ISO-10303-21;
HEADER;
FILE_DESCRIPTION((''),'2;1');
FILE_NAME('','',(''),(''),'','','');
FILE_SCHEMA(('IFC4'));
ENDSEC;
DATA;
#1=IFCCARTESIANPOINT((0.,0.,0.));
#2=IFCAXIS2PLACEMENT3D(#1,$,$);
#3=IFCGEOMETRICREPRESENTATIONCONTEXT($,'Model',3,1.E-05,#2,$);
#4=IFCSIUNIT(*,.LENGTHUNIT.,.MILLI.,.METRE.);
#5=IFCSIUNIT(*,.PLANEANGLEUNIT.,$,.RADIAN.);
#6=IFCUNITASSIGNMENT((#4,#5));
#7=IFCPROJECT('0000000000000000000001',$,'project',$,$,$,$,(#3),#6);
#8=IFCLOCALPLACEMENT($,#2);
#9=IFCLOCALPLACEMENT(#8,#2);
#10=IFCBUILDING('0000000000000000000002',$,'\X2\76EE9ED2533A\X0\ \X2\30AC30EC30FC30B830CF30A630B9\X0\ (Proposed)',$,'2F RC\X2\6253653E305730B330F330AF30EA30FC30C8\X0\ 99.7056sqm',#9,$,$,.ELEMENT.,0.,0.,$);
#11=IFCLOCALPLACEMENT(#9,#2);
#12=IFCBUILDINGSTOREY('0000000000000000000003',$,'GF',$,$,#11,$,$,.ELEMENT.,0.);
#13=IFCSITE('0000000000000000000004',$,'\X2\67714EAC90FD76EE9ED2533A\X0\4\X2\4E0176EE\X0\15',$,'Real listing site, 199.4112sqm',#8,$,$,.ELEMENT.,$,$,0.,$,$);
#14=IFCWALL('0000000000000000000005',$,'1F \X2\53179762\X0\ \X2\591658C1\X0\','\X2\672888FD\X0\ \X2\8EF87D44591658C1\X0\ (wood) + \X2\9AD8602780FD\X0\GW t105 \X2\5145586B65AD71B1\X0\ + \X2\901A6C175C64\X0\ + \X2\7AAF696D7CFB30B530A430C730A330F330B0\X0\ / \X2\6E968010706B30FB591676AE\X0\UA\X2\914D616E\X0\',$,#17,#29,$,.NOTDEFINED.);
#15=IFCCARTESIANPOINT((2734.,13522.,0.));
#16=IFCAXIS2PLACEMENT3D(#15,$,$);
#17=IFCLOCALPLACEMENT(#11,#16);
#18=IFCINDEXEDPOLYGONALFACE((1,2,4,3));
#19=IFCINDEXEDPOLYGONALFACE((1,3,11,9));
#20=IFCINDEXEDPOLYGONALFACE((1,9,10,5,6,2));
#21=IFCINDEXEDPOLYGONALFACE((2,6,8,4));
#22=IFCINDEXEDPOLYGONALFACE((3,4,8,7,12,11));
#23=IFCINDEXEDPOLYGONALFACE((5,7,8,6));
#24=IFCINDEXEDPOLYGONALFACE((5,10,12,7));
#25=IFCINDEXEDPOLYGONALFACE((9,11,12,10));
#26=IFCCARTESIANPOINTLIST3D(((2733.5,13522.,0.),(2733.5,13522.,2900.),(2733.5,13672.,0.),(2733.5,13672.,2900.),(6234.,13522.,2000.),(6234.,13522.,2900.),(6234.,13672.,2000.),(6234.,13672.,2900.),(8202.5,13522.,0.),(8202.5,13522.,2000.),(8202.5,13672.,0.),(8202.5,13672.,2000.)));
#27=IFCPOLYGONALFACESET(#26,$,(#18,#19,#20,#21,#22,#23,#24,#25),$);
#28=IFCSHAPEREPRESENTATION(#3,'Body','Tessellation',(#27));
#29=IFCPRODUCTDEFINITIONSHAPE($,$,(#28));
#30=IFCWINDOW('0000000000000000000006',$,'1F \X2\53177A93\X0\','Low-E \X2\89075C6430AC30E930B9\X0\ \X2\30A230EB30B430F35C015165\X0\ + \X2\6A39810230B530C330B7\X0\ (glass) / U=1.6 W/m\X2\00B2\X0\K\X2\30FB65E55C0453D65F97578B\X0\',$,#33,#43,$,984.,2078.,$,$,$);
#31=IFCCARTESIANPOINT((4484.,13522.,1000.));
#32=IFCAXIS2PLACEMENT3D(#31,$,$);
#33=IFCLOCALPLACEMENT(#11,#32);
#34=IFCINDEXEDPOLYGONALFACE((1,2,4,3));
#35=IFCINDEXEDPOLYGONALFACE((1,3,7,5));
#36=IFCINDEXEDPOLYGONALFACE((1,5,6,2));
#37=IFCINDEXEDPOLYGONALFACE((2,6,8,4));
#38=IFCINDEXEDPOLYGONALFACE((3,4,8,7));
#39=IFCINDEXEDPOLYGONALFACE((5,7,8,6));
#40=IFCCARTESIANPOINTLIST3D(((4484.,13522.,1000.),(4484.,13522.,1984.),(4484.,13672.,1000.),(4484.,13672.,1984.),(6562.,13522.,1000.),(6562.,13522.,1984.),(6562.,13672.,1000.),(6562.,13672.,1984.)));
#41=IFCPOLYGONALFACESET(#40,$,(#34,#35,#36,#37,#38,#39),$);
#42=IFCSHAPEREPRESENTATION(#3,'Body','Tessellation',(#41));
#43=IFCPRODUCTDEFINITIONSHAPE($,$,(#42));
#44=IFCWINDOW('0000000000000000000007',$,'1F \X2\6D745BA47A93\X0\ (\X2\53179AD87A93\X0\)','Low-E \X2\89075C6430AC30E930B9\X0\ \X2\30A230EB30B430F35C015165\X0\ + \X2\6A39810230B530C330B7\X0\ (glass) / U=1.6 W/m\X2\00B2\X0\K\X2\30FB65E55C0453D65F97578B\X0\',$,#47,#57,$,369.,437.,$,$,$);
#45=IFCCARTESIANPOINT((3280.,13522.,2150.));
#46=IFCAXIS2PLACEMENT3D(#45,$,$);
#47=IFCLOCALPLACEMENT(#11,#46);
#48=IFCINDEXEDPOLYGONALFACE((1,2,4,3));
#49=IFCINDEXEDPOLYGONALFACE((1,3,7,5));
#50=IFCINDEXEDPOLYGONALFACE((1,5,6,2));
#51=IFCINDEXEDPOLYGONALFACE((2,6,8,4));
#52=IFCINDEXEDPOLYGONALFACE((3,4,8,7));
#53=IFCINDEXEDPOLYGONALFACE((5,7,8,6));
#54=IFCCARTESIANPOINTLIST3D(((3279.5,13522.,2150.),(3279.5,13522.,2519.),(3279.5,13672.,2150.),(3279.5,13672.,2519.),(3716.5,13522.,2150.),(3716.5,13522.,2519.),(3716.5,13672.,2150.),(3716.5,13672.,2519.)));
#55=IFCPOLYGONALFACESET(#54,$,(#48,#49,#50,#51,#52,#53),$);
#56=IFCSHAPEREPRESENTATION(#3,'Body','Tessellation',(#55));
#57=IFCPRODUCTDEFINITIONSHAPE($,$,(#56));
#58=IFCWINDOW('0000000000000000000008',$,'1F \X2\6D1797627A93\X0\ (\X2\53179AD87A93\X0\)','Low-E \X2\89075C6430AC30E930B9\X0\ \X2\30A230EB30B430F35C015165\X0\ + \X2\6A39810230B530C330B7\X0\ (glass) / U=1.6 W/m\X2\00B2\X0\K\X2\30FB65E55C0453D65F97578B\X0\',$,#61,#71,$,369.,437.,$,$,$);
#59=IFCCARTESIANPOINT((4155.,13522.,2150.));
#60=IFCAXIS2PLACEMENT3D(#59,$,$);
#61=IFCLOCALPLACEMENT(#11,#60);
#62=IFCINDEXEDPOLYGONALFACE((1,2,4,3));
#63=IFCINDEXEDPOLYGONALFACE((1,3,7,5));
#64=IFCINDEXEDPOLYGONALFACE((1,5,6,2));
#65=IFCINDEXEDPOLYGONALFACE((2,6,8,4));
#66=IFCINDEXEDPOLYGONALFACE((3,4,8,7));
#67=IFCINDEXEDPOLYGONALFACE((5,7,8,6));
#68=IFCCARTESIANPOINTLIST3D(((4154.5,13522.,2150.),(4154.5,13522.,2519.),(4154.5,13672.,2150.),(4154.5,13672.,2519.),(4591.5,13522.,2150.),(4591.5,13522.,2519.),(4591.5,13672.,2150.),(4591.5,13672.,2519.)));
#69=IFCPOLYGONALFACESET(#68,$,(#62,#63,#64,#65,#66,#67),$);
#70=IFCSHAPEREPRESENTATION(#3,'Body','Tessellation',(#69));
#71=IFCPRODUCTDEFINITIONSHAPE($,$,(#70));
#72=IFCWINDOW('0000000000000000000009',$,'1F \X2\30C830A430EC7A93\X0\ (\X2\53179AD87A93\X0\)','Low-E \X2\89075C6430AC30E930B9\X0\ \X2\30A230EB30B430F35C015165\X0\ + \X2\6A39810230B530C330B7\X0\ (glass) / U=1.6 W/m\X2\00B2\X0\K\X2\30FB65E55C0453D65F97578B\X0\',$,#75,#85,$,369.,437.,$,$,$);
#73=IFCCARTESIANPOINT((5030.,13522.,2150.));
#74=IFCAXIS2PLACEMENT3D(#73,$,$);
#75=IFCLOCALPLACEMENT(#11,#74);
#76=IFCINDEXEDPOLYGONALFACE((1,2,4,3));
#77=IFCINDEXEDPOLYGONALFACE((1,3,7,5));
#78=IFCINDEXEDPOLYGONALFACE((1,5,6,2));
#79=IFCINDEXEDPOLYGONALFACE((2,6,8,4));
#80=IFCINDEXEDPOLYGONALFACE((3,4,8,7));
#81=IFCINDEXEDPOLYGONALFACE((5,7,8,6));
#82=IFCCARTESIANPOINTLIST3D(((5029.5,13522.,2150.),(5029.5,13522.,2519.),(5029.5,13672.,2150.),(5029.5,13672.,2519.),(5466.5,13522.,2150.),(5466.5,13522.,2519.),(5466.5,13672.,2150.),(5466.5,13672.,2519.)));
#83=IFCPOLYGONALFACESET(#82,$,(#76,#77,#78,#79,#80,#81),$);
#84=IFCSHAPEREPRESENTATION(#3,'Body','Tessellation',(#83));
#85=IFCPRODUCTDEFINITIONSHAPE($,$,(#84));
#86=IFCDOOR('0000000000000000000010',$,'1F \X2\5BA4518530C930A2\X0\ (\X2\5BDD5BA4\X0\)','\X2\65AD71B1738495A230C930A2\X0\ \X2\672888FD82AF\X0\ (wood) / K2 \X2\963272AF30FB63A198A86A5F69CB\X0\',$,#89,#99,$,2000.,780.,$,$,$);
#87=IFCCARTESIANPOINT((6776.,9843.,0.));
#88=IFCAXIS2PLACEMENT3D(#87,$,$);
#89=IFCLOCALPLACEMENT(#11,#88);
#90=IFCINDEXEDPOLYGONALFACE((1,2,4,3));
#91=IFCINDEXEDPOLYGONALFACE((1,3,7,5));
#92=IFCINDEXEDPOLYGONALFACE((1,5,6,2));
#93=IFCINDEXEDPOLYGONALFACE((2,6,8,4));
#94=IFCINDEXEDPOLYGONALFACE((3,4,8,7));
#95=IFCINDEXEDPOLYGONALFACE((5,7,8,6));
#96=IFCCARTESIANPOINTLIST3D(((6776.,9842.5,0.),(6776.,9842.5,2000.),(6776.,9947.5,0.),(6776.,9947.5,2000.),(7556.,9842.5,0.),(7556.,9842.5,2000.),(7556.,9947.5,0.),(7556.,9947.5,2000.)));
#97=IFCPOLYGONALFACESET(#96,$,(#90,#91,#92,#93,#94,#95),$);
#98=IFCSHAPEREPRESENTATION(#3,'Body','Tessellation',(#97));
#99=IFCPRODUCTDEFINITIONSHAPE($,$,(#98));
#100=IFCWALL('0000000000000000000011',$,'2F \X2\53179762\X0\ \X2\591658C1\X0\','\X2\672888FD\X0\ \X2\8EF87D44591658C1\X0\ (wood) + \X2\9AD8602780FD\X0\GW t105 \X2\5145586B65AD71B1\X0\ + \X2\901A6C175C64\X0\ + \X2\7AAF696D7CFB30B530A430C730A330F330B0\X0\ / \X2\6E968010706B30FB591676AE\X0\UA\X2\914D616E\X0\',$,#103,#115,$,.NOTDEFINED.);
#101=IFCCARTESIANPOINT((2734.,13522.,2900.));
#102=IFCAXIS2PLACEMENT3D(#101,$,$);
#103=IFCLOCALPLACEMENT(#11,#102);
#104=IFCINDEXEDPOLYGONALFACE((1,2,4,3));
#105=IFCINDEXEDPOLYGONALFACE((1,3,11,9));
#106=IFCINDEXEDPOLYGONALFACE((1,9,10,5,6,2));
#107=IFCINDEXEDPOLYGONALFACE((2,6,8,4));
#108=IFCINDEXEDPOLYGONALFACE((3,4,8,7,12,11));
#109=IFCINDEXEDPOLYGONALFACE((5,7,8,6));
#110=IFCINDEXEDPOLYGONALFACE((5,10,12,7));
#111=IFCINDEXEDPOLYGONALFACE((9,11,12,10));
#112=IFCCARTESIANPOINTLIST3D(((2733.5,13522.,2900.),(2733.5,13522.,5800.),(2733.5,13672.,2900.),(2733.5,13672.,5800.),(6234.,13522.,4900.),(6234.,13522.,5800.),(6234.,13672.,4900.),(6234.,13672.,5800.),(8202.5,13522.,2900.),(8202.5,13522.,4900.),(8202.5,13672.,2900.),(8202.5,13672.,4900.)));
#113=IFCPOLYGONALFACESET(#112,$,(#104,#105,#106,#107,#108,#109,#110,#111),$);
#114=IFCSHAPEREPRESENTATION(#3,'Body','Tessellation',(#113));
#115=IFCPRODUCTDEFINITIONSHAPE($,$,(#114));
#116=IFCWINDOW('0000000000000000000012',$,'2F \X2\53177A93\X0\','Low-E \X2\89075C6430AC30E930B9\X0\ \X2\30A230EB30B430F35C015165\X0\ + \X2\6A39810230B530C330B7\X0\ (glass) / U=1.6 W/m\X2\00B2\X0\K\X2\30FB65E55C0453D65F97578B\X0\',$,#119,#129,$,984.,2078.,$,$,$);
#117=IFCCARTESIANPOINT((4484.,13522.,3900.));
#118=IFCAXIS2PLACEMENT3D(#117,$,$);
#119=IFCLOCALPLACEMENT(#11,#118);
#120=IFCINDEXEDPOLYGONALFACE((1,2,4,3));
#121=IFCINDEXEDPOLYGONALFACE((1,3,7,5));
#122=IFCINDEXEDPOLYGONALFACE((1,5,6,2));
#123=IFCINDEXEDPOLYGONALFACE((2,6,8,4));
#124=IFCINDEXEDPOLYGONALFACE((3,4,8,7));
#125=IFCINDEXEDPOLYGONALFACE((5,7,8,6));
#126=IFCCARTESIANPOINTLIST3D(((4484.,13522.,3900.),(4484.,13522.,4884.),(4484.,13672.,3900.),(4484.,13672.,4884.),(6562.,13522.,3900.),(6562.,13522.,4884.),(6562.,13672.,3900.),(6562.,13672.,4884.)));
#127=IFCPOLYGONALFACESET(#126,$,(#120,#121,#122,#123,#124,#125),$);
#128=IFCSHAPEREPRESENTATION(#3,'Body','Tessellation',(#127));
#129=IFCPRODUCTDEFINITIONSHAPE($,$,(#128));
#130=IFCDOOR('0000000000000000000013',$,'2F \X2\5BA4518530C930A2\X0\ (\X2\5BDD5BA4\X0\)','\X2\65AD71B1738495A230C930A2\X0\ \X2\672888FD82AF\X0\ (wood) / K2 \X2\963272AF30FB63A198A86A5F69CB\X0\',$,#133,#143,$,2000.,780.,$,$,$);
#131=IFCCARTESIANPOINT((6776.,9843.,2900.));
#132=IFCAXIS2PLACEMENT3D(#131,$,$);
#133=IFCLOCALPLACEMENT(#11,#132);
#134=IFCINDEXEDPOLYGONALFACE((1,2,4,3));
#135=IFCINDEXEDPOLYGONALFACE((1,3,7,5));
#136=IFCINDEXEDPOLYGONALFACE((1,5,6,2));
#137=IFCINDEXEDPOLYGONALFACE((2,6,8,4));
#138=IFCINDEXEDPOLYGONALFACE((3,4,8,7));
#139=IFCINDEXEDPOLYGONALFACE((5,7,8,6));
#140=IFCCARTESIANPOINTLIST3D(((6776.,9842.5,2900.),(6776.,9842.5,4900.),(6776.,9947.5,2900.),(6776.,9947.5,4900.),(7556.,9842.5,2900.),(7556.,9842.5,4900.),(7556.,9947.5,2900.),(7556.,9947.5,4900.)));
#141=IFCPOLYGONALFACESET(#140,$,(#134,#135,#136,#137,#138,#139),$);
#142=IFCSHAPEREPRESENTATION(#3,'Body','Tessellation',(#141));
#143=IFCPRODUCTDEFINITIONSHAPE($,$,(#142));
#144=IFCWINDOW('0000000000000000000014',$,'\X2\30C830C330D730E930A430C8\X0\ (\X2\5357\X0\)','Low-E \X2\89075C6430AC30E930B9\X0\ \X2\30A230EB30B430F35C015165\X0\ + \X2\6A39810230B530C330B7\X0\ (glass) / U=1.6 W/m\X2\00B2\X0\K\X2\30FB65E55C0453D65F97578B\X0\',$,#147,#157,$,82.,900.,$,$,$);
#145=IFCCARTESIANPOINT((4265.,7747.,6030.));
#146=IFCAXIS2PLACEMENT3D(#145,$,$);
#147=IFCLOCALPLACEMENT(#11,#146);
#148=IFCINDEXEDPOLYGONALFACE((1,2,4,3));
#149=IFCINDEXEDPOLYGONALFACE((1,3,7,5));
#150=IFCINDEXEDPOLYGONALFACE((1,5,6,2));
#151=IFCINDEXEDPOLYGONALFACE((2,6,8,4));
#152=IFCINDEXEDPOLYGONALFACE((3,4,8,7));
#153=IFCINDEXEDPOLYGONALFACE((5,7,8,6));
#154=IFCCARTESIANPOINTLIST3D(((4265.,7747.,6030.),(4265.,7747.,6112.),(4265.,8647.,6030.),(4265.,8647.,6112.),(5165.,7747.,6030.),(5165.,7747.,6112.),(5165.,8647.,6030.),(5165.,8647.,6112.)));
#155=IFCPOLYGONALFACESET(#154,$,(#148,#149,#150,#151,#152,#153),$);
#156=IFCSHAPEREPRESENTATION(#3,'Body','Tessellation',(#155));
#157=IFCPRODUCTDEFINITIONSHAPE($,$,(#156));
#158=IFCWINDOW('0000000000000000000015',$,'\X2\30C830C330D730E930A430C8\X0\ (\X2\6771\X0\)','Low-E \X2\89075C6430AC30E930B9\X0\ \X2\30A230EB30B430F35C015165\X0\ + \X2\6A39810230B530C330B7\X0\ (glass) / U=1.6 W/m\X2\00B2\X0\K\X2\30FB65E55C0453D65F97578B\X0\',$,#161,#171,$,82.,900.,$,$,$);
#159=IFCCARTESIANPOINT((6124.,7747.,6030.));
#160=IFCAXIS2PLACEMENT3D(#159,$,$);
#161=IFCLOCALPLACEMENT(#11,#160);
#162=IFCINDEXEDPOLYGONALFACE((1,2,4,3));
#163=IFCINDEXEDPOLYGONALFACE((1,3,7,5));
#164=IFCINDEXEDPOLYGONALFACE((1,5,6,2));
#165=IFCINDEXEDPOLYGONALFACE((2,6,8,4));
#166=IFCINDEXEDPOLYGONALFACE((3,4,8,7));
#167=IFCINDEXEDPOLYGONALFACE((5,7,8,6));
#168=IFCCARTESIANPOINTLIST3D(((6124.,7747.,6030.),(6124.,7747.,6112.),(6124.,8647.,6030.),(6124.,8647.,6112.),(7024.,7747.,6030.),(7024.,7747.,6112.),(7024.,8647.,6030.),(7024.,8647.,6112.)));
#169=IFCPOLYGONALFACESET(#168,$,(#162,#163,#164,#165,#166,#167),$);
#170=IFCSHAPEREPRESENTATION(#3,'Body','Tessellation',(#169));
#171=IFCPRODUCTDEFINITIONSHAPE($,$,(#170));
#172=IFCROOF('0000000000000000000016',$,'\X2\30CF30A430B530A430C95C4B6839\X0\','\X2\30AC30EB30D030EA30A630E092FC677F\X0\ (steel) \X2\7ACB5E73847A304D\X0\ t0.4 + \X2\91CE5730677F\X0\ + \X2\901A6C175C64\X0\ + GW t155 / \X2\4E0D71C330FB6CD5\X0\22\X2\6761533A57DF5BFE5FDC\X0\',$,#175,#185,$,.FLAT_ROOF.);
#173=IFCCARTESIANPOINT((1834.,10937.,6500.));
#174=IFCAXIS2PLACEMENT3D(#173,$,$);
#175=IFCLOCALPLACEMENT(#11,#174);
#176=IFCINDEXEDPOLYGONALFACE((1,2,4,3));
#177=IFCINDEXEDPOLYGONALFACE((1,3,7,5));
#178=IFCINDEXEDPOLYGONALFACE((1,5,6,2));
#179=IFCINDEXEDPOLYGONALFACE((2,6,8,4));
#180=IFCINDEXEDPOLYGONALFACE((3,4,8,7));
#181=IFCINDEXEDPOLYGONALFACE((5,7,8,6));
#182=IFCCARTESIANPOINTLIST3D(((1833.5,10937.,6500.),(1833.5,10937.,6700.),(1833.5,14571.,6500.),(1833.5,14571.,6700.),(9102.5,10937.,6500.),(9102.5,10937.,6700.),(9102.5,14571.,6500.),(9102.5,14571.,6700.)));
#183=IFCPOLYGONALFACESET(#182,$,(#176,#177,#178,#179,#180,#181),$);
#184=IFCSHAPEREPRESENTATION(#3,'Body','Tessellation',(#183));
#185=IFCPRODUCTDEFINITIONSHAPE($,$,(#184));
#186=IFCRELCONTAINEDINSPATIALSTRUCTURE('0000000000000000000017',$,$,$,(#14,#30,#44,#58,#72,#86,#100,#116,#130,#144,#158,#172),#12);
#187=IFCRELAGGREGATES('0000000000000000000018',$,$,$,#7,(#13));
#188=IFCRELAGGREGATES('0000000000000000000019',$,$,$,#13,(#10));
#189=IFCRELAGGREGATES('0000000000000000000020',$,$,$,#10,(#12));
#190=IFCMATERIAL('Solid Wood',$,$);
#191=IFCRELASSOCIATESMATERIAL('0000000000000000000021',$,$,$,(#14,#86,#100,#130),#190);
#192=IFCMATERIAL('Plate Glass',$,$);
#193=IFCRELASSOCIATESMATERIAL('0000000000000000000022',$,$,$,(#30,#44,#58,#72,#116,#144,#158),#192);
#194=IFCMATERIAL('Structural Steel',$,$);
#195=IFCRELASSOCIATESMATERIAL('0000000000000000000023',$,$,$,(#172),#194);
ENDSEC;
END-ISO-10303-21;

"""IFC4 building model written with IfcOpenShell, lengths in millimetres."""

from ifc_helpers import new_model, si_unit, frame, frame_2d, origin, place, context, project, spatial, rectangle, extrude, material, element, fill, save


model = new_model("IFC4")

# Units and contexts
model_context = context("Model", 3, precision=1e-05, world=origin())
ifc_project = project(units=[si_unit("LENGTHUNIT", "METRE", prefix="MILLI"), si_unit("PLANEANGLEUNIT", "RADIAN")], contexts=[model_context])

# Site, building, storey
site_placement = place(None, origin())
site = spatial("IfcSite", under=ifc_project, at=site_placement, Name="東京都目黒区4丁目15", ObjectType="Real listing site, 199.4112sqm", CompositionType="ELEMENT", RefElevation=0.0)
building_placement = place(site_placement, origin())
building = spatial("IfcBuilding", under=site, at=building_placement, Name="目黒区 ガレージハウス (Proposed)", ObjectType="2F RC打放しコンクリート 99.7056sqm", CompositionType="ELEMENT", ElevationOfRefHeight=0.0, ElevationOfTerrain=0.0)
storey_placement = place(building_placement, origin())
storey = spatial("IfcBuildingStorey", under=building, at=storey_placement, Name="GF", CompositionType="ELEMENT", Elevation=0.0)

# Wall, openings, windows
ifc_material_1 = material(Name="Solid Wood")
wall_1_placement = place(storey_placement, frame((2734.0, 13522.0, 0.0)))
wall_1 = element("IfcWall", 1, at=wall_1_placement, inside=storey, material=ifc_material_1, Name="1F 北面 外壁", Description="木製 軸組外壁 (wood) + 高性能GW t105 充填断熱 + 通気層 + 窯業系サイディング / 準耐火・外皮UA配慮", PredefinedType="NOTDEFINED", context=model_context, shape_type="SweptSolid", body=[
    extrude(rectangle(XDim=5469.0, YDim=150.0, at=frame_2d((2734.0, 75.0))), frame((2734.0, 13522.0, 0.0)), (0.0, 0.0, 1.0), 2900.0),
])
opening_1_placement = place(storey_placement, frame((4484.0, 13522.0, 1000.0)))
opening_1 = element("IfcOpeningElement", 2, at=opening_1_placement, cuts=wall_1, PredefinedType="NOTDEFINED", context=model_context, shape_type="SweptSolid", body=[
    extrude(rectangle(XDim=2078.0, YDim=150.0, at=frame_2d((1039.0, 75.0))), frame((4484.0, 13522.0, 1000.0)), (0.0, 0.0, 1.0), 984.0),
])
opening_2_placement = place(storey_placement, frame((3280.0, 13522.0, 2150.0)))
opening_2 = element("IfcOpeningElement", 3, at=opening_2_placement, cuts=wall_1, PredefinedType="NOTDEFINED", context=model_context, shape_type="SweptSolid", body=[
    extrude(rectangle(XDim=437.0, YDim=150.0, at=frame_2d((218.0, 75.0))), frame((3280.0, 13522.0, 2150.0)), (0.0, 0.0, 1.0), 369.0),
])
opening_3_placement = place(storey_placement, frame((4155.0, 13522.0, 2150.0)))
opening_3 = element("IfcOpeningElement", 4, at=opening_3_placement, cuts=wall_1, PredefinedType="NOTDEFINED", context=model_context, shape_type="SweptSolid", body=[
    extrude(rectangle(XDim=437.0, YDim=150.0, at=frame_2d((218.0, 75.0))), frame((4155.0, 13522.0, 2150.0)), (0.0, 0.0, 1.0), 369.0),
])
opening_4_placement = place(storey_placement, frame((5030.0, 13522.0, 2150.0)))
opening_4 = element("IfcOpeningElement", 5, at=opening_4_placement, cuts=wall_1, PredefinedType="NOTDEFINED", context=model_context, shape_type="SweptSolid", body=[
    extrude(rectangle(XDim=437.0, YDim=150.0, at=frame_2d((218.0, 75.0))), frame((5030.0, 13522.0, 2150.0)), (0.0, 0.0, 1.0), 369.0),
])
ifc_material_2 = material(Name="Plate Glass")
window_1_placement = place(storey_placement, frame((4484.0, 13522.0, 1000.0)))
window_1 = element("IfcWindow", 6, at=window_1_placement, inside=storey, material=ifc_material_2, Name="1F 北窓", Description="Low-E 複層ガラス アルゴン封入 + 樹脂サッシ (glass) / U=1.6 W/m²K・日射取得型", OverallHeight=984.0, OverallWidth=2078.0, context=model_context, shape_type="SweptSolid", body=[
    extrude(rectangle(XDim=2078.0, YDim=150.0, at=frame_2d((1039.0, 75.0))), frame((4484.0, 13522.0, 1000.0)), (0.0, 0.0, 1.0), 984.0),
])
fill(opening_1, window_1)
window_2_placement = place(storey_placement, frame((3280.0, 13522.0, 2150.0)))
window_2 = element("IfcWindow", 7, at=window_2_placement, inside=storey, material=ifc_material_2, Name="1F 浴室窓 (北高窓)", Description="Low-E 複層ガラス アルゴン封入 + 樹脂サッシ (glass) / U=1.6 W/m²K・日射取得型", OverallHeight=369.0, OverallWidth=437.0, context=model_context, shape_type="SweptSolid", body=[
    extrude(rectangle(XDim=437.0, YDim=150.0, at=frame_2d((218.0, 75.0))), frame((3280.0, 13522.0, 2150.0)), (0.0, 0.0, 1.0), 369.0),
])
fill(opening_2, window_2)
window_3_placement = place(storey_placement, frame((4155.0, 13522.0, 2150.0)))
window_3 = element("IfcWindow", 8, at=window_3_placement, inside=storey, material=ifc_material_2, Name="1F 洗面窓 (北高窓)", Description="Low-E 複層ガラス アルゴン封入 + 樹脂サッシ (glass) / U=1.6 W/m²K・日射取得型", OverallHeight=369.0, OverallWidth=437.0, context=model_context, shape_type="SweptSolid", body=[
    extrude(rectangle(XDim=437.0, YDim=150.0, at=frame_2d((218.0, 75.0))), frame((4155.0, 13522.0, 2150.0)), (0.0, 0.0, 1.0), 369.0),
])
fill(opening_3, window_3)
window_4_placement = place(storey_placement, frame((5030.0, 13522.0, 2150.0)))
window_4 = element("IfcWindow", 9, at=window_4_placement, inside=storey, material=ifc_material_2, Name="1F トイレ窓 (北高窓)", Description="Low-E 複層ガラス アルゴン封入 + 樹脂サッシ (glass) / U=1.6 W/m²K・日射取得型", OverallHeight=369.0, OverallWidth=437.0, context=model_context, shape_type="SweptSolid", body=[
    extrude(rectangle(XDim=437.0, YDim=150.0, at=frame_2d((218.0, 75.0))), frame((5030.0, 13522.0, 2150.0)), (0.0, 0.0, 1.0), 369.0),
])
fill(opening_4, window_4)

# Door
door_1_placement = place(storey_placement, frame((6776.0, 9843.0, 0.0)))
element("IfcDoor", 10, at=door_1_placement, inside=storey, material=ifc_material_1, Name="1F 室内ドア (寝室)", Description="断熱玄関ドア 木製芯 (wood) / K2 防犯・採風機構", OverallHeight=2000.0, OverallWidth=780.0, context=model_context, shape_type="SweptSolid", body=[
    extrude(rectangle(XDim=780.0, YDim=105.0, at=frame_2d((390.0, 52.0))), frame((6776.0, 9843.0, 0.0)), (0.0, 0.0, 1.0), 2000.0),
])

# Wall, opening, window
wall_2_placement = place(storey_placement, frame((2734.0, 13522.0, 2900.0)))
wall_2 = element("IfcWall", 11, at=wall_2_placement, inside=storey, material=ifc_material_1, Name="2F 北面 外壁", Description="木製 軸組外壁 (wood) + 高性能GW t105 充填断熱 + 通気層 + 窯業系サイディング / 準耐火・外皮UA配慮", PredefinedType="NOTDEFINED", context=model_context, shape_type="SweptSolid", body=[
    extrude(rectangle(XDim=5469.0, YDim=150.0, at=frame_2d((2734.0, 75.0))), frame((2734.0, 13522.0, 2900.0)), (0.0, 0.0, 1.0), 2900.0),
])
opening_5_placement = place(storey_placement, frame((4484.0, 13522.0, 3900.0)))
opening_5 = element("IfcOpeningElement", 12, at=opening_5_placement, cuts=wall_2, PredefinedType="NOTDEFINED", context=model_context, shape_type="SweptSolid", body=[
    extrude(rectangle(XDim=2078.0, YDim=150.0, at=frame_2d((1039.0, 75.0))), frame((4484.0, 13522.0, 3900.0)), (0.0, 0.0, 1.0), 984.0),
])
window_5_placement = place(storey_placement, frame((4484.0, 13522.0, 3900.0)))
window_5 = element("IfcWindow", 13, at=window_5_placement, inside=storey, material=ifc_material_2, Name="2F 北窓", Description="Low-E 複層ガラス アルゴン封入 + 樹脂サッシ (glass) / U=1.6 W/m²K・日射取得型", OverallHeight=984.0, OverallWidth=2078.0, context=model_context, shape_type="SweptSolid", body=[
    extrude(rectangle(XDim=2078.0, YDim=150.0, at=frame_2d((1039.0, 75.0))), frame((4484.0, 13522.0, 3900.0)), (0.0, 0.0, 1.0), 984.0),
])
fill(opening_5, window_5)

# Door
door_2_placement = place(storey_placement, frame((6776.0, 9843.0, 2900.0)))
element("IfcDoor", 14, at=door_2_placement, inside=storey, material=ifc_material_1, Name="2F 室内ドア (寝室)", Description="断熱玄関ドア 木製芯 (wood) / K2 防犯・採風機構", OverallHeight=2000.0, OverallWidth=780.0, context=model_context, shape_type="SweptSolid", body=[
    extrude(rectangle(XDim=780.0, YDim=105.0, at=frame_2d((390.0, 52.0))), frame((6776.0, 9843.0, 2900.0)), (0.0, 0.0, 1.0), 2000.0),
])

# Windows
window_6_placement = place(storey_placement, frame((4265.0, 7747.0, 6030.0)))
element("IfcWindow", 15, at=window_6_placement, inside=storey, material=ifc_material_2, Name="トップライト (南)", Description="Low-E 複層ガラス アルゴン封入 + 樹脂サッシ (glass) / U=1.6 W/m²K・日射取得型", OverallHeight=82.0, OverallWidth=900.0, context=model_context, shape_type="SweptSolid", body=[
    extrude(rectangle(XDim=900.0, YDim=900.0, at=frame_2d((450.0, 450.0))), frame((4265.0, 7747.0, 6030.0)), (0.0, 0.0, 1.0), 82.0),
])
window_7_placement = place(storey_placement, frame((6124.0, 7747.0, 6030.0)))
element("IfcWindow", 16, at=window_7_placement, inside=storey, material=ifc_material_2, Name="トップライト (東)", Description="Low-E 複層ガラス アルゴン封入 + 樹脂サッシ (glass) / U=1.6 W/m²K・日射取得型", OverallHeight=82.0, OverallWidth=900.0, context=model_context, shape_type="SweptSolid", body=[
    extrude(rectangle(XDim=900.0, YDim=900.0, at=frame_2d((450.0, 450.0))), frame((6124.0, 7747.0, 6030.0)), (0.0, 0.0, 1.0), 82.0),
])

# Roof
ifc_material_3 = material(Name="Structural Steel")
roof_placement = place(storey_placement, frame((1834.0, 10937.0, 6500.0)))
element("IfcRoof", 17, at=roof_placement, inside=storey, material=ifc_material_3, Name="ハイサイド屋根", Description="ガルバリウム鋼板 (steel) 立平葺き t0.4 + 野地板 + 通気層 + GW t155 / 不燃・法22条区域対応", PredefinedType="FLAT_ROOF", context=model_context, shape_type="SweptSolid", body=[
    extrude(rectangle(XDim=7269.0, YDim=3634.0, at=frame_2d((3634.0, 1817.0))), frame((1834.0, 10937.0, 6500.0)), (0.0, 0.0, 1.0), 200.0),
])

save(model, "model.ifc")
